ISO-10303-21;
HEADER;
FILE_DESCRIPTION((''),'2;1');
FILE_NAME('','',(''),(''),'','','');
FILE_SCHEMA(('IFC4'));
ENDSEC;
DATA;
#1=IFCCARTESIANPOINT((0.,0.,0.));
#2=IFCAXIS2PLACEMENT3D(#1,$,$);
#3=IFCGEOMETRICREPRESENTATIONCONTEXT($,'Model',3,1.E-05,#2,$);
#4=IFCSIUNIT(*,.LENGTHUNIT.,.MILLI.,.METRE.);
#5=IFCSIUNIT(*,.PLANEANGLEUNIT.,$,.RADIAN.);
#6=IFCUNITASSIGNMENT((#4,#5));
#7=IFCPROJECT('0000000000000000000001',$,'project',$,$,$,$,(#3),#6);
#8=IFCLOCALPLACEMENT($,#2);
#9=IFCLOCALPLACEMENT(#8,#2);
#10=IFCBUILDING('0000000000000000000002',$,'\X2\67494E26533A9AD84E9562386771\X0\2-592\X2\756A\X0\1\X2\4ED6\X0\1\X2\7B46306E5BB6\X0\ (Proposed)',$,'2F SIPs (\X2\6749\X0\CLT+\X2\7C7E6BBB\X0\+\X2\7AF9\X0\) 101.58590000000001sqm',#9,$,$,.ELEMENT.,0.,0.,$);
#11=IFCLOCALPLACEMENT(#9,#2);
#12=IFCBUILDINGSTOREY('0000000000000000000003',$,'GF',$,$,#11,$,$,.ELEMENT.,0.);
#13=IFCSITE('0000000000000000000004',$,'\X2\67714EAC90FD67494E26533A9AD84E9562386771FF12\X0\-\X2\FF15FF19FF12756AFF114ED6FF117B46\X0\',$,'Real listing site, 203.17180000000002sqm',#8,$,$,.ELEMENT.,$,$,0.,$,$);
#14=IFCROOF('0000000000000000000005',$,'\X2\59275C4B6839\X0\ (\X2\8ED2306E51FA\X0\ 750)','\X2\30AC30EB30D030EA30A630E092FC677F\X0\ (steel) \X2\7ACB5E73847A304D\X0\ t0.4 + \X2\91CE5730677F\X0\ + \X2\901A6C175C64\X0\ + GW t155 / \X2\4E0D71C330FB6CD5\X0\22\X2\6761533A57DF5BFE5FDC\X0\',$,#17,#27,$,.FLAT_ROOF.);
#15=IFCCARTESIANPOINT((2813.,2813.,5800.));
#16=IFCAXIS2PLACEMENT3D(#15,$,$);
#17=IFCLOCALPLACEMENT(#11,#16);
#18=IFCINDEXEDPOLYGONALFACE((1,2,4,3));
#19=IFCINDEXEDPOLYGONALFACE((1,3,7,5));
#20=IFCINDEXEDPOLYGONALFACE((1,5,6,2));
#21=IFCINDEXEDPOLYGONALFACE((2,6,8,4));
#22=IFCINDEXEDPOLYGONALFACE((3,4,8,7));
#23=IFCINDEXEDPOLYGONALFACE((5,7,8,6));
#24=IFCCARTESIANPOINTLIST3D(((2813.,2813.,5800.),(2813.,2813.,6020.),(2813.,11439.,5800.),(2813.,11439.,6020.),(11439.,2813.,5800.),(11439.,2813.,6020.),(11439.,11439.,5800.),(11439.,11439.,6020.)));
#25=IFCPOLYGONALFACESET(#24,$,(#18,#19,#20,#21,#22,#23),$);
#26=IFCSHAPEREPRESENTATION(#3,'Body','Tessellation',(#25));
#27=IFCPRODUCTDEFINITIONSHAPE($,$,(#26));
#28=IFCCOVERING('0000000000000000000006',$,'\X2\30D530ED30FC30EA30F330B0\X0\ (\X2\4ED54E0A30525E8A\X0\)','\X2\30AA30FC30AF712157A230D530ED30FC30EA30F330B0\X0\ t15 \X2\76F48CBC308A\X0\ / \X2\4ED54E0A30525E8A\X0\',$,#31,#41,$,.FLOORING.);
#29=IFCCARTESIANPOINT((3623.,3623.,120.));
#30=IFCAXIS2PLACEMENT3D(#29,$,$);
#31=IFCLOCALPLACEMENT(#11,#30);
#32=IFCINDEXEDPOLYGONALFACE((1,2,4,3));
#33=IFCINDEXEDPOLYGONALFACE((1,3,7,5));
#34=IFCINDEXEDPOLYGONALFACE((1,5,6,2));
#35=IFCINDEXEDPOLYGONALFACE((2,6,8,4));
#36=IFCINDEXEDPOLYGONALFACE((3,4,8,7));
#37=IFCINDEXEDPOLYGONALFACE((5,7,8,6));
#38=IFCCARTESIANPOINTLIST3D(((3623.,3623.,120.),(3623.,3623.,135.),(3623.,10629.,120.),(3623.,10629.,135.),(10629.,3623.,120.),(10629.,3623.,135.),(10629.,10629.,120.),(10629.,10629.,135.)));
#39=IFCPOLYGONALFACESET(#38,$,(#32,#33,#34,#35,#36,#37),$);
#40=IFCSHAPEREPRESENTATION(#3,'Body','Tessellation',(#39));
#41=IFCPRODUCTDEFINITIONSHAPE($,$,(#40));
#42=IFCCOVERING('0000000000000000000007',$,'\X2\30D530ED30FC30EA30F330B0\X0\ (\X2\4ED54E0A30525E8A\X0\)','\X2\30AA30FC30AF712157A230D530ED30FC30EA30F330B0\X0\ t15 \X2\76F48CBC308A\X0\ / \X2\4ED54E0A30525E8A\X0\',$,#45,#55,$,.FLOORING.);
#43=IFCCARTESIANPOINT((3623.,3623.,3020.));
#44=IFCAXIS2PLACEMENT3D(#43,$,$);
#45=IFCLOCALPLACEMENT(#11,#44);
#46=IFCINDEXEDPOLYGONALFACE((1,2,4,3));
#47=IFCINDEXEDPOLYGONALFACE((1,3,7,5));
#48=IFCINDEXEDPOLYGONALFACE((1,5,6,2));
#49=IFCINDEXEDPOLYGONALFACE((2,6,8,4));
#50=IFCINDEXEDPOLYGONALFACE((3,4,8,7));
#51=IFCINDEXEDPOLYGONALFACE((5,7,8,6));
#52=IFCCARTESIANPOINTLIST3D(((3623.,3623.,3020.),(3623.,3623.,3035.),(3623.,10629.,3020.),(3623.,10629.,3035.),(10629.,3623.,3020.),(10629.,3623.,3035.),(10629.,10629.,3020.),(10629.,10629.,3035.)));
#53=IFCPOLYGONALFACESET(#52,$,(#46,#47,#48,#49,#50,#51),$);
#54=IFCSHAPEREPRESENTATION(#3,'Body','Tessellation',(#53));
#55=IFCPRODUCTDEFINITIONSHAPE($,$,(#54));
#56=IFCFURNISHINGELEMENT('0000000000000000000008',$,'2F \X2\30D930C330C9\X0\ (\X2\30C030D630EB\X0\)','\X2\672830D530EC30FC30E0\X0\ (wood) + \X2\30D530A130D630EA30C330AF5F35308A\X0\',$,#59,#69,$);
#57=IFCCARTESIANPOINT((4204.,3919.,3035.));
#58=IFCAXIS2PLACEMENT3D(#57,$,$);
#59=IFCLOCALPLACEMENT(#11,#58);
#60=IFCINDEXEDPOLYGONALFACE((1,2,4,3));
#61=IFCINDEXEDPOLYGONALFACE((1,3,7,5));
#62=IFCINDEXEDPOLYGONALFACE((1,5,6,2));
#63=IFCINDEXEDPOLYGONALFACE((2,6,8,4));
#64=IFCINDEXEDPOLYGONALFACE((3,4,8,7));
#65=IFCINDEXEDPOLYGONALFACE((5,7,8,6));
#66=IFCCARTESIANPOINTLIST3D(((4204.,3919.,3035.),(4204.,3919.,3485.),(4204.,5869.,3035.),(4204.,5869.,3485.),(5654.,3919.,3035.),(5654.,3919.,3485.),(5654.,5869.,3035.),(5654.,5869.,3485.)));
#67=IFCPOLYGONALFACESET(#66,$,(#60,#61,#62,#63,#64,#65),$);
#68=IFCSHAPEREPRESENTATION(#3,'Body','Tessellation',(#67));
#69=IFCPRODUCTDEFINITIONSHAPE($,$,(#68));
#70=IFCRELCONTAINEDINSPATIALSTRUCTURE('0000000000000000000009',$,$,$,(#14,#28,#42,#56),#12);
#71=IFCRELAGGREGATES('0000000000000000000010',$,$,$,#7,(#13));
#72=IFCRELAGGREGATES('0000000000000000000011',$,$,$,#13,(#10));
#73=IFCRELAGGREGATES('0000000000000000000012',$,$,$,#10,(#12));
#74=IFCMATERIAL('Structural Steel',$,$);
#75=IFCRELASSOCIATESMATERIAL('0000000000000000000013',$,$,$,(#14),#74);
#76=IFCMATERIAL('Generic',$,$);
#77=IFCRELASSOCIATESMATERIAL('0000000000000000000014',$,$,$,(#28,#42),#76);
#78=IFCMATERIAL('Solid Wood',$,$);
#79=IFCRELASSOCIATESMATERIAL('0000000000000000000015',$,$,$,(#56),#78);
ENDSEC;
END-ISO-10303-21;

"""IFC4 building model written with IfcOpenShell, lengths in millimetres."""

from ifc_helpers import new_model, si_unit, frame, frame_2d, origin, place, context, project, spatial, rectangle, extrude, material, element, save


model = new_model("IFC4")

# Units and contexts
model_context = context("Model", 3, precision=1e-05, world=origin())
ifc_project = project(units=[si_unit("LENGTHUNIT", "METRE", prefix="MILLI"), si_unit("PLANEANGLEUNIT", "RADIAN")], contexts=[model_context])

# Site, building, storey
site_placement = place(None, origin())
site = spatial("IfcSite", under=ifc_project, at=site_placement, Name="東京都杉並区高井戸東２-５９２番１他１筆", ObjectType="Real listing site, 203.17180000000002sqm", CompositionType="ELEMENT", RefElevation=0.0)
building_placement = place(site_placement, origin())
building = spatial("IfcBuilding", under=site, at=building_placement, Name="杉並区高井戸東2-592番1他1筆の家 (Proposed)", ObjectType="2F SIPs (杉CLT+籾殻+竹) 101.58590000000001sqm", CompositionType="ELEMENT", ElevationOfRefHeight=0.0, ElevationOfTerrain=0.0)
storey_placement = place(building_placement, origin())
storey = spatial("IfcBuildingStorey", under=building, at=storey_placement, Name="GF", CompositionType="ELEMENT", Elevation=0.0)

# Shared definitions
ifc_material_1 = material(Name="Solid Wood")

# Roof
ifc_material_2 = material(Name="Structural Steel")
roof_placement = place(storey_placement, frame((2813.0, 2813.0, 5800.0)))
element("IfcRoof", 1, at=roof_placement, inside=storey, material=ifc_material_2, Name="大屋根 (軒の出 750)", Description="ガルバリウム鋼板 (steel) 立平葺き t0.4 + 野地板 + 通気層 + GW t155 / 不燃・法22条区域対応", PredefinedType="FLAT_ROOF", context=model_context, shape_type="SweptSolid", body=[
    extrude(rectangle(XDim=8626.0, YDim=8626.0, at=frame_2d((4313.0, 4313.0))), frame((2813.0, 2813.0, 5800.0)), (0.0, 0.0, 1.0), 220.0),
])

# Coverings
ifc_material_3 = material(Name="Generic")
covering_1_placement = place(storey_placement, frame((3623.0, 3623.0, 120.0)))
element("IfcCovering", 2, at=covering_1_placement, inside=storey, material=ifc_material_3, Name="フローリング (仕上げ床)", Description="オーク無垢フローリング t15 直貼り / 仕上げ床", PredefinedType="FLOORING", context=model_context, shape_type="SweptSolid", body=[
    extrude(rectangle(XDim=7006.0, YDim=7006.0, at=frame_2d((3503.0, 3503.0))), frame((3623.0, 3623.0, 120.0)), (0.0, 0.0, 1.0), 15.0),
])
covering_2_placement = place(storey_placement, frame((3623.0, 3623.0, 3020.0)))
element("IfcCovering", 3, at=covering_2_placement, inside=storey, material=ifc_material_3, Name="フローリング (仕上げ床)", Description="オーク無垢フローリング t15 直貼り / 仕上げ床", PredefinedType="FLOORING", context=model_context, shape_type="SweptSolid", body=[
    extrude(rectangle(XDim=7006.0, YDim=7006.0, at=frame_2d((3503.0, 3503.0))), frame((3623.0, 3623.0, 3020.0)), (0.0, 0.0, 1.0), 15.0),
])

# Furnishing element
furnishing_placement = place(storey_placement, frame((4204.0, 3919.0, 3035.0)))
element("IfcFurnishingElement", 4, at=furnishing_placement, inside=storey, material=ifc_material_1, Name="2F ベッド (ダブル)", Description="木フレーム (wood) + ファブリック張り", context=model_context, shape_type="SweptSolid", body=[
    extrude(rectangle(XDim=1450.0, YDim=1950.0, at=frame_2d((725.0, 975.0))), frame((4204.0, 3919.0, 3035.0)), (0.0, 0.0, 1.0), 450.0),
])

save(model, "model.ifc")
